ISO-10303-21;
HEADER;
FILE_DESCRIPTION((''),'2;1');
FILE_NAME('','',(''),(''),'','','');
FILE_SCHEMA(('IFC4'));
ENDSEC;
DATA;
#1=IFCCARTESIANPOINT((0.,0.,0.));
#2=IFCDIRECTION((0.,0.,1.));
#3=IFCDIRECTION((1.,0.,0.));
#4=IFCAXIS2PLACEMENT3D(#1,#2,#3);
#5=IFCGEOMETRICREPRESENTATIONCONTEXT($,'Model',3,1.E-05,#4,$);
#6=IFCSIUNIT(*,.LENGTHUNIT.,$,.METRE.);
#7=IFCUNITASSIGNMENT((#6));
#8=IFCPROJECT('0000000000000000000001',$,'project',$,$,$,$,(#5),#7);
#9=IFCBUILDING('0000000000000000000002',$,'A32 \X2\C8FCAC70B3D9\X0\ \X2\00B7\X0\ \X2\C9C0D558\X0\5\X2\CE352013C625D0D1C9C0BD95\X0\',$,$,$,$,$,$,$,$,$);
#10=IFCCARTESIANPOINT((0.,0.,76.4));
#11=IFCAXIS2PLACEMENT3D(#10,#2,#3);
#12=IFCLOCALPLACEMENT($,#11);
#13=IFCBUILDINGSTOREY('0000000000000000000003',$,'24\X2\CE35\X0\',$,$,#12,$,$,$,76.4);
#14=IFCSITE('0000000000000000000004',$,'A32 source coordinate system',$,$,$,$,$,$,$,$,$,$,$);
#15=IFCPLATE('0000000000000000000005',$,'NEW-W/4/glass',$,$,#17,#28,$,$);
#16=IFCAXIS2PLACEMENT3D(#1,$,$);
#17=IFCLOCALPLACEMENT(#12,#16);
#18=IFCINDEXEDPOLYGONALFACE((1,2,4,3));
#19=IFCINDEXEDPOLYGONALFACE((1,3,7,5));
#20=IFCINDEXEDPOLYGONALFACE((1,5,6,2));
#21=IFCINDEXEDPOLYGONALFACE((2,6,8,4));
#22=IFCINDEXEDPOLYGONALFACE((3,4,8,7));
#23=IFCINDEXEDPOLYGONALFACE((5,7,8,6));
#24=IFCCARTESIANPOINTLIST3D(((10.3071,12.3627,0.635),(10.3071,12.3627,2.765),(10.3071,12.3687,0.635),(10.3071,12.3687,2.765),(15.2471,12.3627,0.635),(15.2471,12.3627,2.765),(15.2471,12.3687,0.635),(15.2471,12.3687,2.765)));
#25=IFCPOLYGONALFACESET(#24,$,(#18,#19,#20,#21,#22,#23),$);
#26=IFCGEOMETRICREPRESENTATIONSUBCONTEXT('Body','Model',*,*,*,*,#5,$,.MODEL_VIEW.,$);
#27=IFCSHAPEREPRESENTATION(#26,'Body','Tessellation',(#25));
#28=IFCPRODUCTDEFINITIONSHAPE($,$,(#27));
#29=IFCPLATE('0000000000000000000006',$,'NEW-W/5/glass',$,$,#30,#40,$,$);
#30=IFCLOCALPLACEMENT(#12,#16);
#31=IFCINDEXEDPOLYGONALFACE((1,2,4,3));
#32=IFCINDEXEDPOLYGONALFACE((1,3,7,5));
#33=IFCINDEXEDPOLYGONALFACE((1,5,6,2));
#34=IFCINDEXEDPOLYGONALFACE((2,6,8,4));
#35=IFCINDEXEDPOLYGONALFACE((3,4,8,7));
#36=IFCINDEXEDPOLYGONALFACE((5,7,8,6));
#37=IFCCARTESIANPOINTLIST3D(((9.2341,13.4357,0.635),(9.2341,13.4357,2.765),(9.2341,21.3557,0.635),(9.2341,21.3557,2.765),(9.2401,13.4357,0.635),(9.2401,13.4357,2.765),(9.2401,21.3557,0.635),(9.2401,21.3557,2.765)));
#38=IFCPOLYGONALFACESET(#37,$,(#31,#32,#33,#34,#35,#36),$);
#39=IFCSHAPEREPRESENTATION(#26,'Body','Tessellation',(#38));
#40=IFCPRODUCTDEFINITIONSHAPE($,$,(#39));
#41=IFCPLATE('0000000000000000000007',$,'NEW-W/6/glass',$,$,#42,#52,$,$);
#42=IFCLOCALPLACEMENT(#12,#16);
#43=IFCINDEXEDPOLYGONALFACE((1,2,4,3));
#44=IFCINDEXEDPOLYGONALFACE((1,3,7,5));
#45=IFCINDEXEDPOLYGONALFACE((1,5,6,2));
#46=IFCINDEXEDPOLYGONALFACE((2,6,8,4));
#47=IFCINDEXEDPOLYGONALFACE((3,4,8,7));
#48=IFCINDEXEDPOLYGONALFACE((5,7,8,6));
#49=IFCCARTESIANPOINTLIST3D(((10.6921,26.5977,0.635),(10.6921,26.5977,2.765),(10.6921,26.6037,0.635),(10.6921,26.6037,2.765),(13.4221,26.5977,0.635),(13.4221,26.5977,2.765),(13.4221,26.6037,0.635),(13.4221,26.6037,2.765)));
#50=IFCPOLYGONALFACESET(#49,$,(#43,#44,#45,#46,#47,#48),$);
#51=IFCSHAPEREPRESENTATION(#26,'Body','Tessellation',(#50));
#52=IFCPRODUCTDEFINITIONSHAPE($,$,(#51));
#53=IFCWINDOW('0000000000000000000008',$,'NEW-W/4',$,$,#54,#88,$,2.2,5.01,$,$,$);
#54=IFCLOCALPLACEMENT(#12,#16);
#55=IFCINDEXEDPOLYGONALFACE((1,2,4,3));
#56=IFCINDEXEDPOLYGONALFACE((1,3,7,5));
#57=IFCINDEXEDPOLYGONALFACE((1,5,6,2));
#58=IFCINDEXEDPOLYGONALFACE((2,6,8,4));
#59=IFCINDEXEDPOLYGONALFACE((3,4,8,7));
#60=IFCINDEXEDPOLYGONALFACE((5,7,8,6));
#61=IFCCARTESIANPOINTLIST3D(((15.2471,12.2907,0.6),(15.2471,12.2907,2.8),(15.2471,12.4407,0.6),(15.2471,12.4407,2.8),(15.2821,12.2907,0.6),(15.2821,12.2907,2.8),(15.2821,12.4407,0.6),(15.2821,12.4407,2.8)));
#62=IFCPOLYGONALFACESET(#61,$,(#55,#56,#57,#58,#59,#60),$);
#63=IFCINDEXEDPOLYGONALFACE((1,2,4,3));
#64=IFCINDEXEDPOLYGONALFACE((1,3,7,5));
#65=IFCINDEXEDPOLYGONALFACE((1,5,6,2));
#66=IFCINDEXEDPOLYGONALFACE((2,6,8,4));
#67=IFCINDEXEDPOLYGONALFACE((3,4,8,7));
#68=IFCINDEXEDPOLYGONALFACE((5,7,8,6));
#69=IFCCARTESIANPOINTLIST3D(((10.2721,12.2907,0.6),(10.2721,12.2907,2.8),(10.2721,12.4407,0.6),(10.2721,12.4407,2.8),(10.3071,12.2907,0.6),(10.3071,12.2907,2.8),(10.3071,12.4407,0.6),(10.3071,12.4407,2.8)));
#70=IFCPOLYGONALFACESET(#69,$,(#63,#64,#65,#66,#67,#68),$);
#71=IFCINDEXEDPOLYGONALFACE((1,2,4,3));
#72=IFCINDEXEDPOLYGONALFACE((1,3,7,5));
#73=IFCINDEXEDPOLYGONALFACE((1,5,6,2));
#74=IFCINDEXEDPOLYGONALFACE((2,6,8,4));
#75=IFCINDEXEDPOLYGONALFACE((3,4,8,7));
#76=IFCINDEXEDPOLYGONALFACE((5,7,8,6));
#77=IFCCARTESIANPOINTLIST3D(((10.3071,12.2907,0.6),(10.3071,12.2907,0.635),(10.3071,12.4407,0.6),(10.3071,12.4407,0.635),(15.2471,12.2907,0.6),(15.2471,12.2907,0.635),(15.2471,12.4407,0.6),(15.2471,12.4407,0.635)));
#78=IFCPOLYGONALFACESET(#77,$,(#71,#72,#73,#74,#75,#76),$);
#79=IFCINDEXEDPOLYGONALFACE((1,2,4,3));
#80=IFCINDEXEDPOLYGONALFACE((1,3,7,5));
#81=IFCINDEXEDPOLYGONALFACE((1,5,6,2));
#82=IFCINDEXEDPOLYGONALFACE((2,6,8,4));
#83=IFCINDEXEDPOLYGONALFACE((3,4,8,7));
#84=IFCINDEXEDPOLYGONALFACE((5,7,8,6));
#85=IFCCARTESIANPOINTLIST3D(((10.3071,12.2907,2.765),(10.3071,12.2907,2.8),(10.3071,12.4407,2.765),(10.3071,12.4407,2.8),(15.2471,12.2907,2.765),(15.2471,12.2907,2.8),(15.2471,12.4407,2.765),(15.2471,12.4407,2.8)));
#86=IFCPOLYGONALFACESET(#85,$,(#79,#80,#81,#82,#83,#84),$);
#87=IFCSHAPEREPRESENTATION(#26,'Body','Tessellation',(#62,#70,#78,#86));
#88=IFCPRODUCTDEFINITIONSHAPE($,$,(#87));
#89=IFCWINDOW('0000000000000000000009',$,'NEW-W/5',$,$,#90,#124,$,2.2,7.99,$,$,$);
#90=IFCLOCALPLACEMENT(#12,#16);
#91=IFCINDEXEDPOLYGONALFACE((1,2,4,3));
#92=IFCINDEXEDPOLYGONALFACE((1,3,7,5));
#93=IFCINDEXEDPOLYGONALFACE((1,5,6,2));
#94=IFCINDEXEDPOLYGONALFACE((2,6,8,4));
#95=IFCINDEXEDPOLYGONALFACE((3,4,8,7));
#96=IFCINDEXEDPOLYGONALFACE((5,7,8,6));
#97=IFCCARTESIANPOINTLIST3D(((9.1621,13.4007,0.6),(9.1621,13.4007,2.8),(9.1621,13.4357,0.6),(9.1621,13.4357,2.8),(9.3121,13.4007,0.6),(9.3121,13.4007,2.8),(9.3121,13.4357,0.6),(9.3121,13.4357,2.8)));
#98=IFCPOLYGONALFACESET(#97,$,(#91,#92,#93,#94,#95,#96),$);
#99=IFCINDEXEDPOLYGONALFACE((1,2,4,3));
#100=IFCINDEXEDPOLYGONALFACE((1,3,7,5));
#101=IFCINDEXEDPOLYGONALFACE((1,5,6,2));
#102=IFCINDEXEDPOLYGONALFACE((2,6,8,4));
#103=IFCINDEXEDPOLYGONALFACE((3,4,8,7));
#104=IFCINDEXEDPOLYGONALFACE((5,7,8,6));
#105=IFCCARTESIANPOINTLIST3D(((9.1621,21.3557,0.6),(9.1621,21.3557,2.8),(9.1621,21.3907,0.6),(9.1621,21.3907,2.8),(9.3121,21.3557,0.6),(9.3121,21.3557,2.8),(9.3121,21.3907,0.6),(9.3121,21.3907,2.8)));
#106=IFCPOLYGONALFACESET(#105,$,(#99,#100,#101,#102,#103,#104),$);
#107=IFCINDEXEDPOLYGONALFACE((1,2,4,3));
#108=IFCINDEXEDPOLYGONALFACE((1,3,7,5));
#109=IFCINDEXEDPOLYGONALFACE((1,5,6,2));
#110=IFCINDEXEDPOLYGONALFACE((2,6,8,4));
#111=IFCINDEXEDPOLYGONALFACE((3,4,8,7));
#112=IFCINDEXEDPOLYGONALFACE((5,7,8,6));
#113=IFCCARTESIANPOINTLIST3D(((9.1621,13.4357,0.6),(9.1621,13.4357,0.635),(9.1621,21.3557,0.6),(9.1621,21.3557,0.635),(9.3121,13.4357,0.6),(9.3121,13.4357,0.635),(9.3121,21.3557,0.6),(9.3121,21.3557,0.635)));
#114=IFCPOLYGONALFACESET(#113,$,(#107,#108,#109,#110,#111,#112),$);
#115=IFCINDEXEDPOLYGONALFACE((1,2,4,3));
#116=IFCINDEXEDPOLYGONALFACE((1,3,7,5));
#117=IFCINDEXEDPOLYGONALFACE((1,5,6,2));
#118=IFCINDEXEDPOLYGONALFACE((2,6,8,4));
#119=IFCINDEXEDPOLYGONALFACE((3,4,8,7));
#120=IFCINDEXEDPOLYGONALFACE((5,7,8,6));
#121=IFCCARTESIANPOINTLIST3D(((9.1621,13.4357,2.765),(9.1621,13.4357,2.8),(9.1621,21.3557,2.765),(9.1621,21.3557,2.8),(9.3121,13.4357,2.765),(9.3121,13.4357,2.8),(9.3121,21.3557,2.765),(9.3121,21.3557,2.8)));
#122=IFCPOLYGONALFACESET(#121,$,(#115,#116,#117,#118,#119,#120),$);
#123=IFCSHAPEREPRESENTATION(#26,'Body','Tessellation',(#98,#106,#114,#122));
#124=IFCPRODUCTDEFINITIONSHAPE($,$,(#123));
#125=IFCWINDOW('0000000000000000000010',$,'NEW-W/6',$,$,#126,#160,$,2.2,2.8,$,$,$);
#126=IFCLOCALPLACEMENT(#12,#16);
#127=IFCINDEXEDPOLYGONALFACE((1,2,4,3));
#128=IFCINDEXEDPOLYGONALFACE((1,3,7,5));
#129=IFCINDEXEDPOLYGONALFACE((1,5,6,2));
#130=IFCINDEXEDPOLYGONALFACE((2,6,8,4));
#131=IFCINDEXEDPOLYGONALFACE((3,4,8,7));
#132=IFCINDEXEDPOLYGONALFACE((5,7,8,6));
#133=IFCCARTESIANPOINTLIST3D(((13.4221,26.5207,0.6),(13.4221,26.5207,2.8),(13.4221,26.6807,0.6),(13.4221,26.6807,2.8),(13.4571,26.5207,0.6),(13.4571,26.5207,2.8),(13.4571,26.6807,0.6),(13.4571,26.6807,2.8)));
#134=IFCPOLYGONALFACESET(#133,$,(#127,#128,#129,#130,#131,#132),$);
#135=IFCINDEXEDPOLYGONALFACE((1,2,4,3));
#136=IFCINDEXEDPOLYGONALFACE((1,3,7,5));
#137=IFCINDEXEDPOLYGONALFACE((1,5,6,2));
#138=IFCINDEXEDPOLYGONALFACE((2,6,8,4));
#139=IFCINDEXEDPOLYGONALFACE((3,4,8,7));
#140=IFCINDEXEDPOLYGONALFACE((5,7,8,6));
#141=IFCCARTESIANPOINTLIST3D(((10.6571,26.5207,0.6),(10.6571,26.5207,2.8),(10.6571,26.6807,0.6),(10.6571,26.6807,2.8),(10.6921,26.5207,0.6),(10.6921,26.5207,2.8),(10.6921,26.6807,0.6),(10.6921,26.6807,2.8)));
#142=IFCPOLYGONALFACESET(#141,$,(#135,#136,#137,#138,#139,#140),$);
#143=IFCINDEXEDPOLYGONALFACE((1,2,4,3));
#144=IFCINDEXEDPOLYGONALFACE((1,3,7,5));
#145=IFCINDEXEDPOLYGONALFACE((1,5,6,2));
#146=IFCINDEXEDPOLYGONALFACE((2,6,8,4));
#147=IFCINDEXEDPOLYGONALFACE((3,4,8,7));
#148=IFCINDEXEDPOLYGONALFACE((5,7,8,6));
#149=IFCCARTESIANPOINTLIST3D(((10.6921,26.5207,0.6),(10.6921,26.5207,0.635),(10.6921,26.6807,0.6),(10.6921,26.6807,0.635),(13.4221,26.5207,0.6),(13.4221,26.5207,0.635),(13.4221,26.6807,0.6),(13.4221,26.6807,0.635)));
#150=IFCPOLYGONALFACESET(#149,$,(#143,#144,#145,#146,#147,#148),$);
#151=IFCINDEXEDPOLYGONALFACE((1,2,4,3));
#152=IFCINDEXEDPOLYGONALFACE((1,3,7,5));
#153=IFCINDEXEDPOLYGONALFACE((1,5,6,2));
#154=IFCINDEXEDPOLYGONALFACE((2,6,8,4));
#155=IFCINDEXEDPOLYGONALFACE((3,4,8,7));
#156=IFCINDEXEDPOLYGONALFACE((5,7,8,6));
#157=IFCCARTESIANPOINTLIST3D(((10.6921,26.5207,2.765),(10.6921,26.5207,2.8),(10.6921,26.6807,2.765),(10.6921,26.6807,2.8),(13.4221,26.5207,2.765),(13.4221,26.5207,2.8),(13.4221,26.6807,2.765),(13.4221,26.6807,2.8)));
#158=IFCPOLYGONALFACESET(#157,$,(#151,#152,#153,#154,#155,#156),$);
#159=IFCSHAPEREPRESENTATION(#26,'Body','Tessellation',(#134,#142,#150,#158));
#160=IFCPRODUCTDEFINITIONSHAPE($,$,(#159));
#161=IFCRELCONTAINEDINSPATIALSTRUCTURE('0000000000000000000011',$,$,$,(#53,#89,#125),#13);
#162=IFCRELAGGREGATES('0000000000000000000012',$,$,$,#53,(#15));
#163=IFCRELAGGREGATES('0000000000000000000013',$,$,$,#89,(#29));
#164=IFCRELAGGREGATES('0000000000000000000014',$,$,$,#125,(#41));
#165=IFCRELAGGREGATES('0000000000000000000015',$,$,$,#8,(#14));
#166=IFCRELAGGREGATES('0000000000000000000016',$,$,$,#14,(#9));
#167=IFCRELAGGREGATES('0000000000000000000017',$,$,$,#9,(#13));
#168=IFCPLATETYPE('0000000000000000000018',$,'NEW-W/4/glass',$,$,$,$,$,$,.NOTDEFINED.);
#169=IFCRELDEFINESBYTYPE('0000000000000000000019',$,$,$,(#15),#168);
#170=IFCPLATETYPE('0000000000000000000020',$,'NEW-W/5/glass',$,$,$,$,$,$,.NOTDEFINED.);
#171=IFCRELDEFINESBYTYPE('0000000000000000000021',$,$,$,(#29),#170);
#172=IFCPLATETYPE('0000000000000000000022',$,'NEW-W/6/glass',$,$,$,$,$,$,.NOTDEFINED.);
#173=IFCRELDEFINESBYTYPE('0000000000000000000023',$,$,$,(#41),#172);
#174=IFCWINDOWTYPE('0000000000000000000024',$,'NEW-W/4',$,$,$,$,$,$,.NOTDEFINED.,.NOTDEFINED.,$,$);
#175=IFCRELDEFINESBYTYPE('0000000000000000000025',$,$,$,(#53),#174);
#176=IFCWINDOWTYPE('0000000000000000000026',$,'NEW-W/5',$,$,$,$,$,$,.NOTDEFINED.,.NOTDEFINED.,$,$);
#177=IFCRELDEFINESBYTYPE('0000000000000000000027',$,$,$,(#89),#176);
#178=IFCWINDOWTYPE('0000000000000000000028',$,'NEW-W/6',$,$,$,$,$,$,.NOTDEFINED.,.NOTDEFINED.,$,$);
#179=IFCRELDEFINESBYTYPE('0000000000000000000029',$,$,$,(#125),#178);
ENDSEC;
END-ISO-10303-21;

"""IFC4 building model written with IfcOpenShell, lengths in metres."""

from ifc_helpers import new_model, si_unit, frame, origin, origin_with_axes, place, context, subcontext, project, spatial, polyline, outline, extrude, source, transform, mapped, type_object, type_shapes, element, aggregate, save


model = new_model("IFC4")

# Units and contexts
model_context = context("Model", 3, precision=1e-05, world=origin_with_axes())
body_context = subcontext(model_context, "Body", "Model", "MODEL_VIEW")
ifc_project = project(units=[si_unit("LENGTHUNIT", "METRE")], contexts=[model_context])

# Site, building, storey
site = spatial("IfcSite", under=ifc_project, Name="A32 source coordinate system")
building = spatial("IfcBuilding", under=site, Name="A32 주거동 · 지하5층–옥탑지붕")
storey_placement = place(None, frame((0.0, 0.0, 76.4), z_axis=(0.0, 0.0, 1.0), x_axis=(1.0, 0.0, 0.0)))
storey = spatial("IfcBuildingStorey", under=building, at=storey_placement, Name="24층", Elevation=76.4)

# Plates
plate_type_1 = type_object("IfcPlateType", Name="NEW-W/4/glass", PredefinedType="NOTDEFINED")
shared_shape_1 = source(origin(), body_context, "Body", "SweptSolid", [
    extrude(outline(polyline([(15.2471, 12.3627), (10.3071, 12.3627), (10.3071, 12.3687), (15.2471, 12.3687), (15.2471, 12.3627)])), frame((0.0, 0.0, 0.635)), (0.0, 0.0, 1.0), 2.13),
])
type_shapes(plate_type_1, [shared_shape_1])
window_1_placement = place(storey_placement, origin_with_axes())
plate_1_placement = place(window_1_placement, origin_with_axes())
plate_1 = element("IfcPlate", 1, at=plate_1_placement, type_object=plate_type_1, Name="NEW-W/4/glass", context=body_context, shape_type="MappedRepresentation", body=[
    mapped(shared_shape_1, transform((0.0, 0.0, 0.0), scale=1.0)),
])
plate_type_2 = type_object("IfcPlateType", Name="NEW-W/5/glass", PredefinedType="NOTDEFINED")
shared_shape_2 = source(origin(), body_context, "Body", "SweptSolid", [
    extrude(outline(polyline([(9.2401, 13.4357), (9.2341, 13.4357), (9.2341, 21.3557), (9.2401, 21.3557), (9.2401, 13.4357)])), frame((0.0, 0.0, 0.635)), (0.0, 0.0, 1.0), 2.13),
])
type_shapes(plate_type_2, [shared_shape_2])
window_2_placement = place(storey_placement, origin_with_axes())
plate_2_placement = place(window_2_placement, origin_with_axes())
plate_2 = element("IfcPlate", 2, at=plate_2_placement, type_object=plate_type_2, Name="NEW-W/5/glass", context=body_context, shape_type="MappedRepresentation", body=[
    mapped(shared_shape_2, transform((0.0, 0.0, 0.0), scale=1.0)),
])
plate_type_3 = type_object("IfcPlateType", Name="NEW-W/6/glass", PredefinedType="NOTDEFINED")
shared_shape_3 = source(origin(), body_context, "Body", "SweptSolid", [
    extrude(outline(polyline([(13.4221, 26.5977), (10.6921, 26.5977), (10.6921, 26.6037), (13.4221, 26.6037), (13.4221, 26.5977)])), frame((0.0, 0.0, 0.635)), (0.0, 0.0, 1.0), 2.13),
])
type_shapes(plate_type_3, [shared_shape_3])
window_3_placement = place(storey_placement, origin_with_axes())
plate_3_placement = place(window_3_placement, origin_with_axes())
plate_3 = element("IfcPlate", 3, at=plate_3_placement, type_object=plate_type_3, Name="NEW-W/6/glass", context=body_context, shape_type="MappedRepresentation", body=[
    mapped(shared_shape_3, transform((0.0, 0.0, 0.0), scale=1.0)),
])

# Windows
window_type_1 = type_object("IfcWindowType", Name="NEW-W/4", PartitioningType="NOTDEFINED", PredefinedType="NOTDEFINED")
shared_shape_4 = source(origin(), body_context, "Body", "SweptSolid", [
    extrude(outline(polyline([(15.2471, 12.2907), (15.2471, 12.4407), (15.2821, 12.4407), (15.2821, 12.2907), (15.2471, 12.2907)])), frame((0.0, 0.0, 0.6)), (0.0, 0.0, 1.0), 2.2),
    extrude(outline(polyline([(10.2721, 12.2907), (10.2721, 12.4407), (10.3071, 12.4407), (10.3071, 12.2907), (10.2721, 12.2907)])), frame((0.0, 0.0, 0.6)), (0.0, 0.0, 1.0), 2.2),
    extrude(outline(polyline([(15.2471, 12.2907), (15.2471, 12.4407), (10.3071, 12.4407), (10.3071, 12.2907), (15.2471, 12.2907)])), frame((0.0, 0.0, 0.6)), (0.0, 0.0, 1.0), 0.035),
    extrude(outline(polyline([(15.2471, 12.2907), (15.2471, 12.4407), (10.3071, 12.4407), (10.3071, 12.2907), (15.2471, 12.2907)])), frame((0.0, 0.0, 2.765)), (0.0, 0.0, 1.0), 0.035),
])
type_shapes(window_type_1, [shared_shape_4])
window_1 = element("IfcWindow", 4, at=window_1_placement, inside=storey, type_object=window_type_1, Name="NEW-W/4", OverallHeight=2.2, OverallWidth=5.01, context=body_context, shape_type="MappedRepresentation", body=[
    mapped(shared_shape_4, transform((0.0, 0.0, 0.0), scale=1.0)),
])
aggregate(window_1, [plate_1])
window_type_2 = type_object("IfcWindowType", Name="NEW-W/5", PartitioningType="NOTDEFINED", PredefinedType="NOTDEFINED")
shared_shape_5 = source(origin(), body_context, "Body", "SweptSolid", [
    extrude(outline(polyline([(9.1621, 13.4007), (9.1621, 13.4357), (9.3121, 13.4357), (9.3121, 13.4007), (9.1621, 13.4007)])), frame((0.0, 0.0, 0.6)), (0.0, 0.0, 1.0), 2.2),
    extrude(outline(polyline([(9.1621, 21.3557), (9.1621, 21.3907), (9.3121, 21.3907), (9.3121, 21.3557), (9.1621, 21.3557)])), frame((0.0, 0.0, 0.6)), (0.0, 0.0, 1.0), 2.2),
    extrude(outline(polyline([(9.3121, 13.4357), (9.3121, 21.3557), (9.1621, 21.3557), (9.1621, 13.4357), (9.3121, 13.4357)])), frame((0.0, 0.0, 0.6)), (0.0, 0.0, 1.0), 0.035),
    extrude(outline(polyline([(9.3121, 13.4357), (9.3121, 21.3557), (9.1621, 21.3557), (9.1621, 13.4357), (9.3121, 13.4357)])), frame((0.0, 0.0, 2.765)), (0.0, 0.0, 1.0), 0.035),
])
type_shapes(window_type_2, [shared_shape_5])
window_2 = element("IfcWindow", 5, at=window_2_placement, inside=storey, type_object=window_type_2, Name="NEW-W/5", OverallHeight=2.2, OverallWidth=7.99, context=body_context, shape_type="MappedRepresentation", body=[
    mapped(shared_shape_5, transform((0.0, 0.0, 0.0), scale=1.0)),
])
aggregate(window_2, [plate_2])
window_type_3 = type_object("IfcWindowType", Name="NEW-W/6", PartitioningType="NOTDEFINED", PredefinedType="NOTDEFINED")
shared_shape_6 = source(origin(), body_context, "Body", "SweptSolid", [
    extrude(outline(polyline([(13.4221, 26.5207), (13.4221, 26.6807), (13.4571, 26.6807), (13.4571, 26.5207), (13.4221, 26.5207)])), frame((0.0, 0.0, 0.6)), (0.0, 0.0, 1.0), 2.2),
    extrude(outline(polyline([(10.6571, 26.5207), (10.6571, 26.6807), (10.6921, 26.6807), (10.6921, 26.5207), (10.6571, 26.5207)])), frame((0.0, 0.0, 0.6)), (0.0, 0.0, 1.0), 2.2),
    extrude(outline(polyline([(13.4221, 26.5207), (13.4221, 26.6807), (10.6921, 26.6807), (10.6921, 26.5207), (13.4221, 26.5207)])), frame((0.0, 0.0, 0.6)), (0.0, 0.0, 1.0), 0.035),
    extrude(outline(polyline([(13.4221, 26.5207), (13.4221, 26.6807), (10.6921, 26.6807), (10.6921, 26.5207), (13.4221, 26.5207)])), frame((0.0, 0.0, 2.765)), (0.0, 0.0, 1.0), 0.035),
])
type_shapes(window_type_3, [shared_shape_6])
window_3 = element("IfcWindow", 6, at=window_3_placement, inside=storey, type_object=window_type_3, Name="NEW-W/6", OverallHeight=2.2, OverallWidth=2.8, context=body_context, shape_type="MappedRepresentation", body=[
    mapped(shared_shape_6, transform((0.0, 0.0, 0.0), scale=1.0)),
])
aggregate(window_3, [plate_3])

save(model, "model.ifc")
